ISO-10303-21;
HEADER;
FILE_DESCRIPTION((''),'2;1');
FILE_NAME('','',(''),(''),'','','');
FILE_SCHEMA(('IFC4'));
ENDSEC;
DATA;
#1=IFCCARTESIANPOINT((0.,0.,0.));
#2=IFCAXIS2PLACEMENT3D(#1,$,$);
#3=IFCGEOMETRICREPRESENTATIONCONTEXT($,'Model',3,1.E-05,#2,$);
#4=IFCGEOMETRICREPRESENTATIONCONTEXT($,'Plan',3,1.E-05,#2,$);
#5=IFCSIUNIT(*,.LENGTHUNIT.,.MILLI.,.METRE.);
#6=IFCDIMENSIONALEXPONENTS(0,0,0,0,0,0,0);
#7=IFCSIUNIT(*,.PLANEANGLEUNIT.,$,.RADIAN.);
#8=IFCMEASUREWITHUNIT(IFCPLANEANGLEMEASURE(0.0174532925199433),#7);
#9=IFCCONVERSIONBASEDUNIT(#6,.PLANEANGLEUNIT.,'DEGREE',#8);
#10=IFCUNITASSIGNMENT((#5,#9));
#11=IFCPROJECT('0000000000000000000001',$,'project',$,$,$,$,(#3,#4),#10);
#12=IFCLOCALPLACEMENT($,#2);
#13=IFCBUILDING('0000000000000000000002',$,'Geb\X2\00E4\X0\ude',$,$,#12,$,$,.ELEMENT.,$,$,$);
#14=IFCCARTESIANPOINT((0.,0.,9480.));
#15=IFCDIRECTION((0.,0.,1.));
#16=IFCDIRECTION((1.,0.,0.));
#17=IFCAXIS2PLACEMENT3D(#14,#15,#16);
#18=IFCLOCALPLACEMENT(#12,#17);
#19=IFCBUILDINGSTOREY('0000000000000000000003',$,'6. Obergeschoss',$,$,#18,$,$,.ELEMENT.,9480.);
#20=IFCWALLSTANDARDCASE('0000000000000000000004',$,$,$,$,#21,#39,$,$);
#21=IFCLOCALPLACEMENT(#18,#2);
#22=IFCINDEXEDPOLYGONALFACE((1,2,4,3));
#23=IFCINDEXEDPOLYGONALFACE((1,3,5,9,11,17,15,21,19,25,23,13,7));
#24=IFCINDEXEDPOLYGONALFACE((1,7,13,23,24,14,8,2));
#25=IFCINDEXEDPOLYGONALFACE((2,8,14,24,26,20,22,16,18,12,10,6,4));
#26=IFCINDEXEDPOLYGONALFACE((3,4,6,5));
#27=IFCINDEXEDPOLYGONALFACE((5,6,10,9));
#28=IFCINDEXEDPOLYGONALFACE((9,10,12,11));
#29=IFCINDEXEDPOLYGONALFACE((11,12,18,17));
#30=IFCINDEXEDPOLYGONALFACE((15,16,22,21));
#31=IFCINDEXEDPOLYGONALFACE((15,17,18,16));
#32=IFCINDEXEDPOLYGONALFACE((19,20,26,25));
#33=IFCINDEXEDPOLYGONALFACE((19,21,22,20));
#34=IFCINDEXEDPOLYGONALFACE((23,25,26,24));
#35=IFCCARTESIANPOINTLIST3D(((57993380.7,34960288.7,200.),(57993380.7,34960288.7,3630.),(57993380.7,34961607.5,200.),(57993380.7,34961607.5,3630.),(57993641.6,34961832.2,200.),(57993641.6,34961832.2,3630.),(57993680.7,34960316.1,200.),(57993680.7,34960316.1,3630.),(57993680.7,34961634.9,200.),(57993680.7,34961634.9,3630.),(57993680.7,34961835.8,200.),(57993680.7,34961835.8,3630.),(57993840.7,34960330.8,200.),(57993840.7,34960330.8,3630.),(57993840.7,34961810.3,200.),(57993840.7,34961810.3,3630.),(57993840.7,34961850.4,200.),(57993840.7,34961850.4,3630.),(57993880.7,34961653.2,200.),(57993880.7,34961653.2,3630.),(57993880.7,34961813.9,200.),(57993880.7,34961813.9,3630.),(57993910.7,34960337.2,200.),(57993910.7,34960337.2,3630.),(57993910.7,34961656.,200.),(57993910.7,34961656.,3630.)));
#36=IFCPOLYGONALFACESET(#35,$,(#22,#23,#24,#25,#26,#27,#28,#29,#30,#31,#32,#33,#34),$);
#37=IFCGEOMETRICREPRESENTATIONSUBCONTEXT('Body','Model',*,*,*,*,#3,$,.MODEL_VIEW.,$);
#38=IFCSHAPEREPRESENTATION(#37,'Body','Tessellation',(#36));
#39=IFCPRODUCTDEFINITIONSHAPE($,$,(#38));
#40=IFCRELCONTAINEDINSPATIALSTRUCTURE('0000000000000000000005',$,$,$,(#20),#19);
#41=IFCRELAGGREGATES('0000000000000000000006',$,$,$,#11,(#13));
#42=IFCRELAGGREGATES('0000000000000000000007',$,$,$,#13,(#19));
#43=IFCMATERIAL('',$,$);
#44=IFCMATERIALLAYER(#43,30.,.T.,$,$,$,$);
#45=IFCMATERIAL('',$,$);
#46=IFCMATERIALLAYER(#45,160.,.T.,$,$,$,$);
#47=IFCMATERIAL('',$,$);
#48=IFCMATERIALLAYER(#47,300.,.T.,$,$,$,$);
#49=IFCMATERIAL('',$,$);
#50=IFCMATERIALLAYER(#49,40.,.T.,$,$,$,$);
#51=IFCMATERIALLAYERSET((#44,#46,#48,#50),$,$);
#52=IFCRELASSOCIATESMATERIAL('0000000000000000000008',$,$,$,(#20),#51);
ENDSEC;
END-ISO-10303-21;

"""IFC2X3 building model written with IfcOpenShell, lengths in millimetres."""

from ifc_helpers import new_model, entity, si_unit, converted_unit, frame, origin, origin_with_axes, place, context, subcontext, project, spatial, polyline, outline, extrude, material, layer, layer_set, layer_usage, element, save


model = new_model("IFC2X3")

# Units and contexts
model_context = context("Model", 3, precision=1e-05, world=origin())
plan_context = context("Plan", 3, precision=1e-05, world=origin())
body_context = subcontext(model_context, "Body", "Model", "MODEL_VIEW")
ifc_project = project(units=[si_unit("LENGTHUNIT", "METRE", prefix="MILLI"), converted_unit("PLANEANGLEUNIT", "DEGREE", entity("IfcPlaneAngleMeasure", 0.0174532925199433), si_unit("PLANEANGLEUNIT", "RADIAN"), dimensions=[0, 0, 0, 0, 0, 0, 0])], contexts=[model_context, plan_context])

# Building, storey
building_placement = place(None, origin())
building = spatial("IfcBuilding", under=ifc_project, at=building_placement, Name="Gebäude", CompositionType="ELEMENT")
storey_placement = place(building_placement, frame((0.0, 0.0, 9480.0), z_axis=(0.0, 0.0, 1.0), x_axis=(1.0, 0.0, 0.0)))
storey = spatial("IfcBuildingStorey", under=building, at=storey_placement, Name="6. Obergeschoss", CompositionType="ELEMENT", Elevation=9480.0)

# Wall
ifc_material_1 = material(Name="")
ifc_layer_1 = layer(ifc_material_1, 30.0, ventilated=True)
ifc_material_2 = material(Name="")
ifc_layer_2 = layer(ifc_material_2, 160.0, ventilated=True)
ifc_material_3 = material(Name="")
ifc_layer_3 = layer(ifc_material_3, 300.0, ventilated=True)
ifc_material_4 = material(Name="")
ifc_layer_4 = layer(ifc_material_4, 40.0, ventilated=True)
ifc_layer_set_1 = layer_set([ifc_layer_1, ifc_layer_2, ifc_layer_3, ifc_layer_4])
ifc_layer_usage_1 = layer_usage(ifc_layer_set_1, "AXIS2", "POSITIVE", 0.0)
wall_1_placement = place(storey_placement, frame((57993380.7, 34961607.5, 200.0), z_axis=(0.0, 0.0, 1.0), x_axis=(0.0, -1.0, 0.0)))
element("IfcWallStandardCase", 1, at=wall_1_placement, inside=storey, material=ifc_layer_usage_1, context=body_context, shape_type="SweptSolid", body=[
    extrude(outline(polyline([(-48.5, 530.0), (-45.8, 500.0), (-206.5, 500.0), (-202.8, 460.0), (-243.0, 460.0), (-228.3, 300.0), (-27.5, 300.0), (-224.7, 260.9), (0.0, 0.0), (1318.7, 0.0), (1291.3, 300.0), (1276.7, 460.0), (1270.3, 530.0), (-48.5, 530.0)])), origin_with_axes(), (0.0, 0.0, 1.0), 3430.0),
])

save(model, "model.ifc")
